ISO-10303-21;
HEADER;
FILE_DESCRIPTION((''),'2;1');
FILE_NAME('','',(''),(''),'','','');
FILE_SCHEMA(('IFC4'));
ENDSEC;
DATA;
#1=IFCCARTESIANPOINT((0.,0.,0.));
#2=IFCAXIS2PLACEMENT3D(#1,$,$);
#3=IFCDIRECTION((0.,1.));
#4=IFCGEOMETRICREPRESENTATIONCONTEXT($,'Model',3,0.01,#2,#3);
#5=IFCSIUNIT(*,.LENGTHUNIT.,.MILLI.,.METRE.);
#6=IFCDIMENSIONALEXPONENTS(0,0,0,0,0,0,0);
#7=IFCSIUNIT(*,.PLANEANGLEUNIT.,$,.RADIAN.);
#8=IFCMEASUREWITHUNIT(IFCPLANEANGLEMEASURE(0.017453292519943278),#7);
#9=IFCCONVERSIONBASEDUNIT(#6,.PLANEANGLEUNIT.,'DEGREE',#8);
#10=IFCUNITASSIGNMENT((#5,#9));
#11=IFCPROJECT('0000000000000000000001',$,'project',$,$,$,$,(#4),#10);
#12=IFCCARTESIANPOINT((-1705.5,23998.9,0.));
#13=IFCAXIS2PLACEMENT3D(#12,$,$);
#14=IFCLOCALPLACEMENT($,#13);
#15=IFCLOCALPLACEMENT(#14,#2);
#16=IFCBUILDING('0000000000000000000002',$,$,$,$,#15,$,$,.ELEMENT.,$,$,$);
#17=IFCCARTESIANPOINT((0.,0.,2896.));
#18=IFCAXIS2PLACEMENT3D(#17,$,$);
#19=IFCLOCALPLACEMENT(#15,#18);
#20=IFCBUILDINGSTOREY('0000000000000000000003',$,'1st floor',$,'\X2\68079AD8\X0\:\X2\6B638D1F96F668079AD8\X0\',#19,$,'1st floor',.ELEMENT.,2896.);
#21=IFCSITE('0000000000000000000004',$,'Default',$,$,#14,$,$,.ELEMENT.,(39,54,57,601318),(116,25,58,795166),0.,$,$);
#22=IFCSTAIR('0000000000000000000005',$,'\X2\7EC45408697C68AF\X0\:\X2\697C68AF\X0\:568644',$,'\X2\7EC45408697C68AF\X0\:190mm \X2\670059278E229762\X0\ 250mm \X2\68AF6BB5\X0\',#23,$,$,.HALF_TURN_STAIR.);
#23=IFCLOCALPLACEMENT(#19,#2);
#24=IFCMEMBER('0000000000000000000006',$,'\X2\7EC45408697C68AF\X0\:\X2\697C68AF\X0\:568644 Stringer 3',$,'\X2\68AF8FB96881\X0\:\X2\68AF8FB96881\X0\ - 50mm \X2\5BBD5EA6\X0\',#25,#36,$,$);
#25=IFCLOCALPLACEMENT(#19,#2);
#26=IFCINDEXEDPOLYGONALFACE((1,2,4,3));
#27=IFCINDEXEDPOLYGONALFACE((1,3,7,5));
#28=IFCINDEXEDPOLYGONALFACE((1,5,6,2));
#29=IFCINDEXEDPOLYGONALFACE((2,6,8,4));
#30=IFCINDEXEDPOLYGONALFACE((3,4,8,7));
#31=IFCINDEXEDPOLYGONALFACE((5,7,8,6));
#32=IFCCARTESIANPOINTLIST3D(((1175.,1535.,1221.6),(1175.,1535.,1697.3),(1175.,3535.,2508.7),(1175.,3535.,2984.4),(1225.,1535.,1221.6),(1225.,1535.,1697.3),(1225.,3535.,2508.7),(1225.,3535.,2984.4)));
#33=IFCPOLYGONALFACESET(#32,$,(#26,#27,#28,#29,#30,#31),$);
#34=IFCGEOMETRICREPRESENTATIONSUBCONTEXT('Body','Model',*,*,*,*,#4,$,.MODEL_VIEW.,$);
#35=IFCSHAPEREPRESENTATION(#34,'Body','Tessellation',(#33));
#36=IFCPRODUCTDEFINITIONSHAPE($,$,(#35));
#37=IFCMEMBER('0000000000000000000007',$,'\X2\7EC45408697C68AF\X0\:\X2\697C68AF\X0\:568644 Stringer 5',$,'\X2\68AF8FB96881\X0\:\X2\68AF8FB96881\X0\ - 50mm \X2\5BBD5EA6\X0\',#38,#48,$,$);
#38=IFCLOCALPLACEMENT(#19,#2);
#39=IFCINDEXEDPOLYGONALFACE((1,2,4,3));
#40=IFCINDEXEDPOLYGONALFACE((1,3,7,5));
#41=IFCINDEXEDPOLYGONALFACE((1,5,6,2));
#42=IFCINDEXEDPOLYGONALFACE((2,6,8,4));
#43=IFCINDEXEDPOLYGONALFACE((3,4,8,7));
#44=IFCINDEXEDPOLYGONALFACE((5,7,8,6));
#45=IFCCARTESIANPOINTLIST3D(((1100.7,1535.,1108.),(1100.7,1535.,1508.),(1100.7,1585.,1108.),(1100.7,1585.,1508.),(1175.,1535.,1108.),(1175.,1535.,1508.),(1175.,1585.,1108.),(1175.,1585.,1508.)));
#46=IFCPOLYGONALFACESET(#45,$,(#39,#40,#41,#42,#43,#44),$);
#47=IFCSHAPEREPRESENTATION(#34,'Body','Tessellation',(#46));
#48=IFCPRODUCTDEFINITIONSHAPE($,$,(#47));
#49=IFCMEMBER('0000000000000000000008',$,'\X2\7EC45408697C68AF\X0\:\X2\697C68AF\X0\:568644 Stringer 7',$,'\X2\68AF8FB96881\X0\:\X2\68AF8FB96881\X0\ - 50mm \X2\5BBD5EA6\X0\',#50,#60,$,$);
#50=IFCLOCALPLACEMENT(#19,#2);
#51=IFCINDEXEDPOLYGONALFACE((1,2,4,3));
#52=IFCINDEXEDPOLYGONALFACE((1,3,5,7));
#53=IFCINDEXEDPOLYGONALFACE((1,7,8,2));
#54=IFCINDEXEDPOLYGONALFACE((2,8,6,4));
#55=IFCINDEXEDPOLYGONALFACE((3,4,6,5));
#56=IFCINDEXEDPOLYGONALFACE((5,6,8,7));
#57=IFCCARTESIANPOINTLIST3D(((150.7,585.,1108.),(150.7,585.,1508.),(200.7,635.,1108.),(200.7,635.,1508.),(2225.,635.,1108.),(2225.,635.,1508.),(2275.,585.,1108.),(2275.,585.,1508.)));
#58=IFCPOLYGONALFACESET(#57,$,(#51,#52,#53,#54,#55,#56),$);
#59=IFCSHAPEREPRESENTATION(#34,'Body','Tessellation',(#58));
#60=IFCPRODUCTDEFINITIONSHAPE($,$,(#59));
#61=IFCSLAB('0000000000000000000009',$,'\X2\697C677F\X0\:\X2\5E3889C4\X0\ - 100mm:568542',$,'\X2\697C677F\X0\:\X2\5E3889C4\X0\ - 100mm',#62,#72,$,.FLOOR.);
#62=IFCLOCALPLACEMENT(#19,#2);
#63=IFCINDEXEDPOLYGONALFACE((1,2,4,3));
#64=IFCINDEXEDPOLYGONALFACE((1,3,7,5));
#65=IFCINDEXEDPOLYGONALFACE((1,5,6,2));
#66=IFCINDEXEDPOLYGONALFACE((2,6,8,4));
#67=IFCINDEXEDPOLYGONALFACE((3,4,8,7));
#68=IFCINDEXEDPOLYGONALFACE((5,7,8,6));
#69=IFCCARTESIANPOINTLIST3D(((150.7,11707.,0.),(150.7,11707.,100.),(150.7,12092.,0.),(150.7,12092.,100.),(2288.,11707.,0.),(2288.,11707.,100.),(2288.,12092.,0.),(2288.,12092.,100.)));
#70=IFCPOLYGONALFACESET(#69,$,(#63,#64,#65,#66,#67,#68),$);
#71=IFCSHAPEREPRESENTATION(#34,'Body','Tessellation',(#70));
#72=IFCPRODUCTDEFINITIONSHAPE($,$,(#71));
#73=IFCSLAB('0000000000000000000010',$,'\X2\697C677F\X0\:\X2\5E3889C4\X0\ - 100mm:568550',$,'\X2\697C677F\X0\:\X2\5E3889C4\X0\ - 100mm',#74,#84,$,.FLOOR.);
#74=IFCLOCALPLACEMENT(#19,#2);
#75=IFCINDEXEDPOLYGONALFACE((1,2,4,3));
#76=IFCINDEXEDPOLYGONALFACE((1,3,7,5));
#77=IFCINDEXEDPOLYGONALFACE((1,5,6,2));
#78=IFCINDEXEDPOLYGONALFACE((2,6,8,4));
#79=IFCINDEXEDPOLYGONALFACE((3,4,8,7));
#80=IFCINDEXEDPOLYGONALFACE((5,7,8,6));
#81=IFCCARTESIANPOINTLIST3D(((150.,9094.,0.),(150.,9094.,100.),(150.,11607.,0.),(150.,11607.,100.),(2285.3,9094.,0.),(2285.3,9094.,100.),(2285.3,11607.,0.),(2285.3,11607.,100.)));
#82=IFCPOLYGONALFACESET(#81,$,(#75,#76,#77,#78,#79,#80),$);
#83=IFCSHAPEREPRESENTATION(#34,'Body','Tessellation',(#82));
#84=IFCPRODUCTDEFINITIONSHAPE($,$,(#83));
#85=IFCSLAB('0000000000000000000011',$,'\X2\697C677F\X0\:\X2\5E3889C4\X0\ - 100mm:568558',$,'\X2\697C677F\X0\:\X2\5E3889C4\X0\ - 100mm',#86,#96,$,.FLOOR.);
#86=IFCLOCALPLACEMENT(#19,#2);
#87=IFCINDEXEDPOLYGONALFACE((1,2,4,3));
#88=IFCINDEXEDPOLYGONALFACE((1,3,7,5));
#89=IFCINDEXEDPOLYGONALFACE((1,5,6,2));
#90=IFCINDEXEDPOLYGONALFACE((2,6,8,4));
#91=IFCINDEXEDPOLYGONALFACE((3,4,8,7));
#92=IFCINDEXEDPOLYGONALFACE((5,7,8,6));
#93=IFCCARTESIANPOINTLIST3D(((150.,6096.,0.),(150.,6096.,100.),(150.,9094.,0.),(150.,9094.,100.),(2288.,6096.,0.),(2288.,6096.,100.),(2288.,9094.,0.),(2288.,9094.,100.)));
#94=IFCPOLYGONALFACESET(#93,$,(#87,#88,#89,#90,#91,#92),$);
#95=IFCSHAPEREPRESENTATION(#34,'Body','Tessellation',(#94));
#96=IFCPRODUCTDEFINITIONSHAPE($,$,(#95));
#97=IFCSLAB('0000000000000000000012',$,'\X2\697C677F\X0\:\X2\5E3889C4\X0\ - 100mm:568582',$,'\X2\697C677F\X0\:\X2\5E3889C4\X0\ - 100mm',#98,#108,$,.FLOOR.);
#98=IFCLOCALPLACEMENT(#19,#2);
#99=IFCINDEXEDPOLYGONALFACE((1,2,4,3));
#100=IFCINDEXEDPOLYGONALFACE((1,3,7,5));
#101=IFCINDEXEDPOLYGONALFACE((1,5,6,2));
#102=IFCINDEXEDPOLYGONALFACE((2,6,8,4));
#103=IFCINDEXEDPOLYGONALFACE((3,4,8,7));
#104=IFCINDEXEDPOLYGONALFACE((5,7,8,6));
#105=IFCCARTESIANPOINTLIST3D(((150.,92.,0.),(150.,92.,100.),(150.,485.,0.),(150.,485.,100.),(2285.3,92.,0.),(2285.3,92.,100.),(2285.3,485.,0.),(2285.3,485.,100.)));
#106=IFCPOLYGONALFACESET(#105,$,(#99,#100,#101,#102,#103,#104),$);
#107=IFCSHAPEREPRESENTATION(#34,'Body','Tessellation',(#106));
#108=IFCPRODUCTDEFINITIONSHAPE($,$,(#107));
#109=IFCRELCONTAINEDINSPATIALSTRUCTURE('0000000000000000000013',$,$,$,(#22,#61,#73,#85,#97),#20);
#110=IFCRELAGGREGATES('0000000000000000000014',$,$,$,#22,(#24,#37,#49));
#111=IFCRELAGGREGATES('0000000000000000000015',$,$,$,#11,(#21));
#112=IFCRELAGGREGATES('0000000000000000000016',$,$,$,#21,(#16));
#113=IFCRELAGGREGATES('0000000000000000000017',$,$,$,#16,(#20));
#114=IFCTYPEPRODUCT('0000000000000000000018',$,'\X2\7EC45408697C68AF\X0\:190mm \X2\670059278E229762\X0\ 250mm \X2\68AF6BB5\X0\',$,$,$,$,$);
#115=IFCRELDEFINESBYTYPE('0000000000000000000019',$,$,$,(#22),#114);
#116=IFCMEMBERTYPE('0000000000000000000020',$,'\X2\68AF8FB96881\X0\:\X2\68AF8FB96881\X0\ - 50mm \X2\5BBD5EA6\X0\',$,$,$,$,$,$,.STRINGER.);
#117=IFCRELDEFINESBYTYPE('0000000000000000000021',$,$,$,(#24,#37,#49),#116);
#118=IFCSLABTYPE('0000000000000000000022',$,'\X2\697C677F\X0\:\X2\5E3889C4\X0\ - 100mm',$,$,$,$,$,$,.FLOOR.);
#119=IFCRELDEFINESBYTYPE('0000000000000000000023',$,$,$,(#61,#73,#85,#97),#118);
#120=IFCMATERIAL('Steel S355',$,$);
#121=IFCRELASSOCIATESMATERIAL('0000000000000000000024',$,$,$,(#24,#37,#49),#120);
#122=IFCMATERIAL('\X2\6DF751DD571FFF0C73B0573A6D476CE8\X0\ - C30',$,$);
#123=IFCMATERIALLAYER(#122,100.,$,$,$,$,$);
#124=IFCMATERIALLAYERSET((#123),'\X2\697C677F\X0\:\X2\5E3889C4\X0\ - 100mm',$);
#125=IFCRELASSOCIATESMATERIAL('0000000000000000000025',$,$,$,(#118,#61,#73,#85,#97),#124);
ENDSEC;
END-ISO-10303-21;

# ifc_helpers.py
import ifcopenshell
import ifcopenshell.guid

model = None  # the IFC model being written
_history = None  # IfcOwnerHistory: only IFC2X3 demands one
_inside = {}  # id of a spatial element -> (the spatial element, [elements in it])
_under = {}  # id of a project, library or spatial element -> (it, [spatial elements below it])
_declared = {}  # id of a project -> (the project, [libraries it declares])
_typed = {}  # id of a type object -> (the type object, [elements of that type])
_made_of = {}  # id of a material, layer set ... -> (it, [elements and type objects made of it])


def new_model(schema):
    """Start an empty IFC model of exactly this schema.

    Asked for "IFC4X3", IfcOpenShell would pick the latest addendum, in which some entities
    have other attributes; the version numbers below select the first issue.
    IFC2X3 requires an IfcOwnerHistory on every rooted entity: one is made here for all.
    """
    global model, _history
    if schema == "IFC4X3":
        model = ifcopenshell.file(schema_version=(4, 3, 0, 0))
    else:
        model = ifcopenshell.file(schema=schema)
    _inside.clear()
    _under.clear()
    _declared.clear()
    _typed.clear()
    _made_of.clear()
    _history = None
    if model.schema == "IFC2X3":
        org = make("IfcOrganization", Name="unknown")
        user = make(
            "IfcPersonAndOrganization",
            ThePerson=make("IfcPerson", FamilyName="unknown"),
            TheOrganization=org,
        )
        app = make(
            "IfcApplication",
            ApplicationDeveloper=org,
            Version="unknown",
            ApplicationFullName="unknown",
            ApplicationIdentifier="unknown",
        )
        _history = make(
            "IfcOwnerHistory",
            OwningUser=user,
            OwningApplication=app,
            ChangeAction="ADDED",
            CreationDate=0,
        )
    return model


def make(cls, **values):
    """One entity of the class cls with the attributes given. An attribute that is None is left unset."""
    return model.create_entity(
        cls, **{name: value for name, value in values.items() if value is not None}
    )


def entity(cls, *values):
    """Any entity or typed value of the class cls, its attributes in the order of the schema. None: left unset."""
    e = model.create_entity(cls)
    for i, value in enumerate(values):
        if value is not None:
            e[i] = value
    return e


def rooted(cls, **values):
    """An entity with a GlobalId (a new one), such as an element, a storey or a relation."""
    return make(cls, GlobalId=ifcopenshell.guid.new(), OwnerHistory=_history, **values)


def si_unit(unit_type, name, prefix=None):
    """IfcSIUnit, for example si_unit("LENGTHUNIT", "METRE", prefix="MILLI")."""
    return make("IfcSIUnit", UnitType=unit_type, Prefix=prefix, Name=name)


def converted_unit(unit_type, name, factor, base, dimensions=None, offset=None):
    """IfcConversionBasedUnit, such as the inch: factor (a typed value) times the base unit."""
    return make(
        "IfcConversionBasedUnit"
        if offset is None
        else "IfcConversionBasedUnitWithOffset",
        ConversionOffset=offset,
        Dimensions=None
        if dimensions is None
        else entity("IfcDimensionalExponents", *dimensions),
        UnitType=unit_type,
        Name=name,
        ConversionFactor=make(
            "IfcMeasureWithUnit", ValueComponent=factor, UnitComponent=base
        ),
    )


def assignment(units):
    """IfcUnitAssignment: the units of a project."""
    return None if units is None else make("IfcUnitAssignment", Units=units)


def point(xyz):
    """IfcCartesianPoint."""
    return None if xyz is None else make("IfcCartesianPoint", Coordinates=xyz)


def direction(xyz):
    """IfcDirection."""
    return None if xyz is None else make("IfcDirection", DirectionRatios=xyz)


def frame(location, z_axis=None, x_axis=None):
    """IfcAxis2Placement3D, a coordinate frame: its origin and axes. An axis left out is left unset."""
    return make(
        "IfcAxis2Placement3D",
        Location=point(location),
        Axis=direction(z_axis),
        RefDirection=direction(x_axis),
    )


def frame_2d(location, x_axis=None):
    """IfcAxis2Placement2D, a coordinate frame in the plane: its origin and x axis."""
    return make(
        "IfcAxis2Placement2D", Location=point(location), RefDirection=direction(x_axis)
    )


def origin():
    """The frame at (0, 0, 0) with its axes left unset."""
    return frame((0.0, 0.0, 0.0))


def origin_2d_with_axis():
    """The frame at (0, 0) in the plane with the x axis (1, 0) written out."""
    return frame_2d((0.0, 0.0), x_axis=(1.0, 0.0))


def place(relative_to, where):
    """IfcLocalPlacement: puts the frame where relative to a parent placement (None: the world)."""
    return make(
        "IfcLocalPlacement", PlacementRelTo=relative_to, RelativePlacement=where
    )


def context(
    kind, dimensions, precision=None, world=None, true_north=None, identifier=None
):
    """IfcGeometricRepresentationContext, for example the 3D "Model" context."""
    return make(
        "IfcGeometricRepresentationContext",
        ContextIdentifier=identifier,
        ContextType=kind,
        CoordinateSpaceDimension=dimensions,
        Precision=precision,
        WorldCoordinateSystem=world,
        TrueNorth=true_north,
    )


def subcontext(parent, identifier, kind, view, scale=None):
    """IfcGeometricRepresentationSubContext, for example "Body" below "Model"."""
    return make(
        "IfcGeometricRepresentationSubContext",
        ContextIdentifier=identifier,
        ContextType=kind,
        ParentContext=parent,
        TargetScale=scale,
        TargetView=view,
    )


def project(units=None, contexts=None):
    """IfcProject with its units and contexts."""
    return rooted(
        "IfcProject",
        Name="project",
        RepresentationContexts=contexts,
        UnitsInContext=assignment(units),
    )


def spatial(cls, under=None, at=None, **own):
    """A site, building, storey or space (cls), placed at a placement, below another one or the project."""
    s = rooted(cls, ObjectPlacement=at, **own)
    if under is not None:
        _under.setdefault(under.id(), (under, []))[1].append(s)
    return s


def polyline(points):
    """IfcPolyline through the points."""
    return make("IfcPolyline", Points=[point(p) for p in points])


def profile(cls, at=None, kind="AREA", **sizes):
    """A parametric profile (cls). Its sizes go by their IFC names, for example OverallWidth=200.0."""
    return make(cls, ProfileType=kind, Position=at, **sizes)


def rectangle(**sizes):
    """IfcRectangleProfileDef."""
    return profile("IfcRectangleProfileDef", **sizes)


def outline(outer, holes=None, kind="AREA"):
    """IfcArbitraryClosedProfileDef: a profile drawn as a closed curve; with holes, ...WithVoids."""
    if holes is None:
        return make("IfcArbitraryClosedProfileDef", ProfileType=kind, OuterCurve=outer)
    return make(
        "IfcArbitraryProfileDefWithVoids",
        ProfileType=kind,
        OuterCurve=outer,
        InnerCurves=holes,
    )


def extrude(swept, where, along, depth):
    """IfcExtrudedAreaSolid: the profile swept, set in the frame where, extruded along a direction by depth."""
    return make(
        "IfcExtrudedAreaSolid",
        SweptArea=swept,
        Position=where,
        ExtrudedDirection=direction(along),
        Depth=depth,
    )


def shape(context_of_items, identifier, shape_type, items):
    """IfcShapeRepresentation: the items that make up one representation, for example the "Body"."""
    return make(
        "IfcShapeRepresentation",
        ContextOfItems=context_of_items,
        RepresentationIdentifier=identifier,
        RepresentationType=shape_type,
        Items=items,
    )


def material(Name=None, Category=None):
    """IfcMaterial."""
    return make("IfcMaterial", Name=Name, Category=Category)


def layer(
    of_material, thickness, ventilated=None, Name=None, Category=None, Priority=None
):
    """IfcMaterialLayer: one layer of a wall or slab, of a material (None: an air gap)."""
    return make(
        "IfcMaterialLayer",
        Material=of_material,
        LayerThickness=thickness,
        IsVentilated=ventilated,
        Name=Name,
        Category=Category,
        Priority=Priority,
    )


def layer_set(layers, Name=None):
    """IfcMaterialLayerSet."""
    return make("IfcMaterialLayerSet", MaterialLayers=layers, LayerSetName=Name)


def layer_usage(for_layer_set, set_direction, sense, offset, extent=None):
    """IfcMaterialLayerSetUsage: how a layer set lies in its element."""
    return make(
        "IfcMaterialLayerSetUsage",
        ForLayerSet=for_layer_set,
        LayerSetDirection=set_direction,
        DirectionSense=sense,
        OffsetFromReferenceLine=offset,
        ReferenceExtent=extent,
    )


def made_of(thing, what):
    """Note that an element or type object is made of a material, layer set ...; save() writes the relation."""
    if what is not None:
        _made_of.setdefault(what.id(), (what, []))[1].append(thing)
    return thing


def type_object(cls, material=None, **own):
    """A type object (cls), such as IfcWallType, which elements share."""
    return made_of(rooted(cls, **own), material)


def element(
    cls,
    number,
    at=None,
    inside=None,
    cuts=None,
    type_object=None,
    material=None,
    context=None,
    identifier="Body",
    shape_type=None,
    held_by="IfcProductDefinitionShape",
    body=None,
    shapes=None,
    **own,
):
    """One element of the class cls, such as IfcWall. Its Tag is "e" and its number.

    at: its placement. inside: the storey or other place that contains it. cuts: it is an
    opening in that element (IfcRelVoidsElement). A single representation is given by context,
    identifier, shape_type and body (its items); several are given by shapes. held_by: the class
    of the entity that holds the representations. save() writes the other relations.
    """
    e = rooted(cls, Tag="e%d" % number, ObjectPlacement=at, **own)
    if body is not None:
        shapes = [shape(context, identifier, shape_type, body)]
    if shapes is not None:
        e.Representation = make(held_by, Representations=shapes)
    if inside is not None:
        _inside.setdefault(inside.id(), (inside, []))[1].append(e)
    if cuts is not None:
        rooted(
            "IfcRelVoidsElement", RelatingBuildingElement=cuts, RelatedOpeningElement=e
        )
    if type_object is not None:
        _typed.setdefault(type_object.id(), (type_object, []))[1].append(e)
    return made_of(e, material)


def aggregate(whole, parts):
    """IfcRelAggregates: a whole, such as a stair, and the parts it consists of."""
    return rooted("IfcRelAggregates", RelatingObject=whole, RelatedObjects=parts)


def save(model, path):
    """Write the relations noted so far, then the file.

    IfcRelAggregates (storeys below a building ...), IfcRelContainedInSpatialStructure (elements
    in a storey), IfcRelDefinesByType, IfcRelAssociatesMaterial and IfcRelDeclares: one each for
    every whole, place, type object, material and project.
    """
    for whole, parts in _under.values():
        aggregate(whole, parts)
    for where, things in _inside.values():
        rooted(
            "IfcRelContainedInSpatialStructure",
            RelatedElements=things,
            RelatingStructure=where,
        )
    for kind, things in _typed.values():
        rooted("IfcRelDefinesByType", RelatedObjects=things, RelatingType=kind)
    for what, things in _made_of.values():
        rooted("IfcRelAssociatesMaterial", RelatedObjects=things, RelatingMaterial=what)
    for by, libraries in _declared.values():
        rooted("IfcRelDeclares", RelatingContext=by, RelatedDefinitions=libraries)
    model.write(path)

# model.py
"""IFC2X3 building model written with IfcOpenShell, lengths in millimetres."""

from ifc_helpers import new_model, entity, si_unit, converted_unit, direction, frame, frame_2d, origin, origin_2d_with_axis, place, context, subcontext, project, spatial, polyline, rectangle, outline, extrude, material, layer, layer_set, layer_usage, type_object, element, aggregate, save


model = new_model("IFC2X3")

# Units and contexts
model_context = context("Model", 3, precision=0.01, world=origin(), true_north=direction((0.0, 1.0)))
body_context = subcontext(model_context, "Body", "Model", "MODEL_VIEW")
ifc_project = project(units=[si_unit("LENGTHUNIT", "METRE", prefix="MILLI"), converted_unit("PLANEANGLEUNIT", "DEGREE", entity("IfcPlaneAngleMeasure", 0.017453292519943278), si_unit("PLANEANGLEUNIT", "RADIAN"), dimensions=[0, 0, 0, 0, 0, 0, 0])], contexts=[model_context])

# Site, building, storey
site_placement = place(None, frame((-1705.5, 23998.9, 0.0)))
site = spatial("IfcSite", under=ifc_project, at=site_placement, Name="Default", CompositionType="ELEMENT", RefLatitude=(39, 54, 57, 601318), RefLongitude=(116, 25, 58, 795166), RefElevation=0.0)
building_placement = place(site_placement, origin())
building = spatial("IfcBuilding", under=site, at=building_placement, CompositionType="ELEMENT")
storey_placement = place(building_placement, frame((0.0, 0.0, 2896.0)))
storey = spatial("IfcBuildingStorey", under=building, at=storey_placement, Name="1st floor", ObjectType="标高:正负零标高", LongName="1st floor", CompositionType="ELEMENT", Elevation=2896.0)

# Stair, members
type_product = type_object("IfcTypeProduct", Name="组合楼梯:190mm 最大踢面 250mm 梯段")
stair_placement = place(storey_placement, origin())
stair = element("IfcStair", 1, at=stair_placement, inside=storey, type_object=type_product, Name="组合楼梯:楼梯:568644", ObjectType="组合楼梯:190mm 最大踢面 250mm 梯段", ShapeType="HALF_TURN_STAIR")
ifc_material_1 = material(Name="Steel S355")
member_type = type_object("IfcMemberType", Name="梯边梁:梯边梁 - 50mm 宽度", PredefinedType="STRINGER")
member_1_placement = place(stair_placement, origin())
member_1 = element("IfcMember", 2, at=member_1_placement, type_object=member_type, material=ifc_material_1, Name="组合楼梯:楼梯:568644 Stringer 3", ObjectType="梯边梁:梯边梁 - 50mm 宽度", context=body_context, shape_type="SweptSolid", body=[
    extrude(outline(polyline([(-1317.9, -200.0), (1060.5, -200.0), (1317.9, 200.0), (-1060.5, 200.0), (-1317.9, -200.0)])), frame((1175.0, 2535.0, 2103.0), z_axis=(1.0, 0.0, 0.0), x_axis=(0.0, 0.840911, 0.541173)), (0.0, 0.0, 1.0), 50.0),
])
member_2_placement = place(stair_placement, origin())
member_2 = element("IfcMember", 3, at=member_2_placement, type_object=member_type, material=ifc_material_1, Name="组合楼梯:楼梯:568644 Stringer 5", ObjectType="梯边梁:梯边梁 - 50mm 宽度", context=body_context, shape_type="SweptSolid", body=[
    extrude(rectangle(XDim=74.3, YDim=50.0, at=frame_2d((0.0, 0.0), x_axis=(1.0, 0.0))), frame((1137.8, 1560.0, 1108.0), z_axis=(0.0, 0.0, 1.0), x_axis=(-1.0, 0.0, 0.0)), (0.0, 0.0, 1.0), 400.0),
])
member_3_placement = place(stair_placement, origin())
member_3 = element("IfcMember", 4, at=member_3_placement, type_object=member_type, material=ifc_material_1, Name="组合楼梯:楼梯:568644 Stringer 7", ObjectType="梯边梁:梯边梁 - 50mm 宽度", context=body_context, shape_type="SweptSolid", body=[
    extrude(outline(polyline([(-1062.2, -25.0), (1062.2, -25.0), (1012.2, 25.0), (-1012.2, 25.0), (-1062.2, -25.0)])), frame((1212.8, 610.0, 1108.0)), (0.0, 0.0, 1.0), 400.0),
])

# Slabs
ifc_material_2 = material(Name="混凝土，现场浇注 - C30")
ifc_layer_1 = layer(ifc_material_2, 100.0)
ifc_layer_set_1 = layer_set([ifc_layer_1], Name="楼板:常规 - 100mm")
ifc_layer_usage_1 = layer_usage(ifc_layer_set_1, "AXIS3", "POSITIVE", 0.0)
slab_type_1 = type_object("IfcSlabType", Name="楼板:常规 - 100mm", PredefinedType="FLOOR", material=ifc_layer_set_1)
slab_1_placement = place(storey_placement, origin())
element("IfcSlab", 5, at=slab_1_placement, inside=storey, type_object=slab_type_1, material=ifc_layer_usage_1, Name="楼板:常规 - 100mm:568542", ObjectType="楼板:常规 - 100mm", PredefinedType="FLOOR", context=body_context, shape_type="SweptSolid", body=[
    extrude(rectangle(XDim=385.0, YDim=2137.3, at=origin_2d_with_axis()), frame((1219.3, 11899.5, 100.0), z_axis=(0.0, 0.0, -1.0), x_axis=(0.0, 1.0, 0.0)), (0.0, 0.0, 1.0), 100.0),
])
ifc_layer_usage_2 = layer_usage(ifc_layer_set_1, "AXIS3", "POSITIVE", 0.0)
slab_2_placement = place(storey_placement, origin())
element("IfcSlab", 6, at=slab_2_placement, inside=storey, type_object=slab_type_1, material=ifc_layer_usage_2, Name="楼板:常规 - 100mm:568550", ObjectType="楼板:常规 - 100mm", PredefinedType="FLOOR", context=body_context, shape_type="SweptSolid", body=[
    extrude(rectangle(XDim=2513.0, YDim=2135.3, at=origin_2d_with_axis()), frame((1217.6, 10350.5, 100.0), z_axis=(0.0, 0.0, -1.0), x_axis=(0.0, 1.0, 0.0)), (0.0, 0.0, 1.0), 100.0),
])
ifc_layer_usage_3 = layer_usage(ifc_layer_set_1, "AXIS3", "POSITIVE", 0.0)
slab_3_placement = place(storey_placement, origin())
element("IfcSlab", 7, at=slab_3_placement, inside=storey, type_object=slab_type_1, material=ifc_layer_usage_3, Name="楼板:常规 - 100mm:568558", ObjectType="楼板:常规 - 100mm", PredefinedType="FLOOR", context=body_context, shape_type="SweptSolid", body=[
    extrude(rectangle(XDim=2998.0, YDim=2138.0, at=origin_2d_with_axis()), frame((1219.0, 7595.0, 100.0), z_axis=(0.0, 0.0, -1.0), x_axis=(0.0, 1.0, 0.0)), (0.0, 0.0, 1.0), 100.0),
])
ifc_layer_usage_4 = layer_usage(ifc_layer_set_1, "AXIS3", "POSITIVE", 0.0)
slab_4_placement = place(storey_placement, origin())
element("IfcSlab", 8, at=slab_4_placement, inside=storey, type_object=slab_type_1, material=ifc_layer_usage_4, Name="楼板:常规 - 100mm:568582", ObjectType="楼板:常规 - 100mm", PredefinedType="FLOOR", context=body_context, shape_type="SweptSolid", body=[
    extrude(rectangle(XDim=393.0, YDim=2135.3, at=frame_2d((0.0, 0.0), x_axis=(1.0, 0.0))), frame((1217.7, 288.5, 100.0), z_axis=(0.0, 0.0, -1.0), x_axis=(0.0, 1.0, 0.0)), (0.0, 0.0, 1.0), 100.0),
])

aggregate(stair, [member_1, member_2, member_3])

save(model, "model.ifc")
